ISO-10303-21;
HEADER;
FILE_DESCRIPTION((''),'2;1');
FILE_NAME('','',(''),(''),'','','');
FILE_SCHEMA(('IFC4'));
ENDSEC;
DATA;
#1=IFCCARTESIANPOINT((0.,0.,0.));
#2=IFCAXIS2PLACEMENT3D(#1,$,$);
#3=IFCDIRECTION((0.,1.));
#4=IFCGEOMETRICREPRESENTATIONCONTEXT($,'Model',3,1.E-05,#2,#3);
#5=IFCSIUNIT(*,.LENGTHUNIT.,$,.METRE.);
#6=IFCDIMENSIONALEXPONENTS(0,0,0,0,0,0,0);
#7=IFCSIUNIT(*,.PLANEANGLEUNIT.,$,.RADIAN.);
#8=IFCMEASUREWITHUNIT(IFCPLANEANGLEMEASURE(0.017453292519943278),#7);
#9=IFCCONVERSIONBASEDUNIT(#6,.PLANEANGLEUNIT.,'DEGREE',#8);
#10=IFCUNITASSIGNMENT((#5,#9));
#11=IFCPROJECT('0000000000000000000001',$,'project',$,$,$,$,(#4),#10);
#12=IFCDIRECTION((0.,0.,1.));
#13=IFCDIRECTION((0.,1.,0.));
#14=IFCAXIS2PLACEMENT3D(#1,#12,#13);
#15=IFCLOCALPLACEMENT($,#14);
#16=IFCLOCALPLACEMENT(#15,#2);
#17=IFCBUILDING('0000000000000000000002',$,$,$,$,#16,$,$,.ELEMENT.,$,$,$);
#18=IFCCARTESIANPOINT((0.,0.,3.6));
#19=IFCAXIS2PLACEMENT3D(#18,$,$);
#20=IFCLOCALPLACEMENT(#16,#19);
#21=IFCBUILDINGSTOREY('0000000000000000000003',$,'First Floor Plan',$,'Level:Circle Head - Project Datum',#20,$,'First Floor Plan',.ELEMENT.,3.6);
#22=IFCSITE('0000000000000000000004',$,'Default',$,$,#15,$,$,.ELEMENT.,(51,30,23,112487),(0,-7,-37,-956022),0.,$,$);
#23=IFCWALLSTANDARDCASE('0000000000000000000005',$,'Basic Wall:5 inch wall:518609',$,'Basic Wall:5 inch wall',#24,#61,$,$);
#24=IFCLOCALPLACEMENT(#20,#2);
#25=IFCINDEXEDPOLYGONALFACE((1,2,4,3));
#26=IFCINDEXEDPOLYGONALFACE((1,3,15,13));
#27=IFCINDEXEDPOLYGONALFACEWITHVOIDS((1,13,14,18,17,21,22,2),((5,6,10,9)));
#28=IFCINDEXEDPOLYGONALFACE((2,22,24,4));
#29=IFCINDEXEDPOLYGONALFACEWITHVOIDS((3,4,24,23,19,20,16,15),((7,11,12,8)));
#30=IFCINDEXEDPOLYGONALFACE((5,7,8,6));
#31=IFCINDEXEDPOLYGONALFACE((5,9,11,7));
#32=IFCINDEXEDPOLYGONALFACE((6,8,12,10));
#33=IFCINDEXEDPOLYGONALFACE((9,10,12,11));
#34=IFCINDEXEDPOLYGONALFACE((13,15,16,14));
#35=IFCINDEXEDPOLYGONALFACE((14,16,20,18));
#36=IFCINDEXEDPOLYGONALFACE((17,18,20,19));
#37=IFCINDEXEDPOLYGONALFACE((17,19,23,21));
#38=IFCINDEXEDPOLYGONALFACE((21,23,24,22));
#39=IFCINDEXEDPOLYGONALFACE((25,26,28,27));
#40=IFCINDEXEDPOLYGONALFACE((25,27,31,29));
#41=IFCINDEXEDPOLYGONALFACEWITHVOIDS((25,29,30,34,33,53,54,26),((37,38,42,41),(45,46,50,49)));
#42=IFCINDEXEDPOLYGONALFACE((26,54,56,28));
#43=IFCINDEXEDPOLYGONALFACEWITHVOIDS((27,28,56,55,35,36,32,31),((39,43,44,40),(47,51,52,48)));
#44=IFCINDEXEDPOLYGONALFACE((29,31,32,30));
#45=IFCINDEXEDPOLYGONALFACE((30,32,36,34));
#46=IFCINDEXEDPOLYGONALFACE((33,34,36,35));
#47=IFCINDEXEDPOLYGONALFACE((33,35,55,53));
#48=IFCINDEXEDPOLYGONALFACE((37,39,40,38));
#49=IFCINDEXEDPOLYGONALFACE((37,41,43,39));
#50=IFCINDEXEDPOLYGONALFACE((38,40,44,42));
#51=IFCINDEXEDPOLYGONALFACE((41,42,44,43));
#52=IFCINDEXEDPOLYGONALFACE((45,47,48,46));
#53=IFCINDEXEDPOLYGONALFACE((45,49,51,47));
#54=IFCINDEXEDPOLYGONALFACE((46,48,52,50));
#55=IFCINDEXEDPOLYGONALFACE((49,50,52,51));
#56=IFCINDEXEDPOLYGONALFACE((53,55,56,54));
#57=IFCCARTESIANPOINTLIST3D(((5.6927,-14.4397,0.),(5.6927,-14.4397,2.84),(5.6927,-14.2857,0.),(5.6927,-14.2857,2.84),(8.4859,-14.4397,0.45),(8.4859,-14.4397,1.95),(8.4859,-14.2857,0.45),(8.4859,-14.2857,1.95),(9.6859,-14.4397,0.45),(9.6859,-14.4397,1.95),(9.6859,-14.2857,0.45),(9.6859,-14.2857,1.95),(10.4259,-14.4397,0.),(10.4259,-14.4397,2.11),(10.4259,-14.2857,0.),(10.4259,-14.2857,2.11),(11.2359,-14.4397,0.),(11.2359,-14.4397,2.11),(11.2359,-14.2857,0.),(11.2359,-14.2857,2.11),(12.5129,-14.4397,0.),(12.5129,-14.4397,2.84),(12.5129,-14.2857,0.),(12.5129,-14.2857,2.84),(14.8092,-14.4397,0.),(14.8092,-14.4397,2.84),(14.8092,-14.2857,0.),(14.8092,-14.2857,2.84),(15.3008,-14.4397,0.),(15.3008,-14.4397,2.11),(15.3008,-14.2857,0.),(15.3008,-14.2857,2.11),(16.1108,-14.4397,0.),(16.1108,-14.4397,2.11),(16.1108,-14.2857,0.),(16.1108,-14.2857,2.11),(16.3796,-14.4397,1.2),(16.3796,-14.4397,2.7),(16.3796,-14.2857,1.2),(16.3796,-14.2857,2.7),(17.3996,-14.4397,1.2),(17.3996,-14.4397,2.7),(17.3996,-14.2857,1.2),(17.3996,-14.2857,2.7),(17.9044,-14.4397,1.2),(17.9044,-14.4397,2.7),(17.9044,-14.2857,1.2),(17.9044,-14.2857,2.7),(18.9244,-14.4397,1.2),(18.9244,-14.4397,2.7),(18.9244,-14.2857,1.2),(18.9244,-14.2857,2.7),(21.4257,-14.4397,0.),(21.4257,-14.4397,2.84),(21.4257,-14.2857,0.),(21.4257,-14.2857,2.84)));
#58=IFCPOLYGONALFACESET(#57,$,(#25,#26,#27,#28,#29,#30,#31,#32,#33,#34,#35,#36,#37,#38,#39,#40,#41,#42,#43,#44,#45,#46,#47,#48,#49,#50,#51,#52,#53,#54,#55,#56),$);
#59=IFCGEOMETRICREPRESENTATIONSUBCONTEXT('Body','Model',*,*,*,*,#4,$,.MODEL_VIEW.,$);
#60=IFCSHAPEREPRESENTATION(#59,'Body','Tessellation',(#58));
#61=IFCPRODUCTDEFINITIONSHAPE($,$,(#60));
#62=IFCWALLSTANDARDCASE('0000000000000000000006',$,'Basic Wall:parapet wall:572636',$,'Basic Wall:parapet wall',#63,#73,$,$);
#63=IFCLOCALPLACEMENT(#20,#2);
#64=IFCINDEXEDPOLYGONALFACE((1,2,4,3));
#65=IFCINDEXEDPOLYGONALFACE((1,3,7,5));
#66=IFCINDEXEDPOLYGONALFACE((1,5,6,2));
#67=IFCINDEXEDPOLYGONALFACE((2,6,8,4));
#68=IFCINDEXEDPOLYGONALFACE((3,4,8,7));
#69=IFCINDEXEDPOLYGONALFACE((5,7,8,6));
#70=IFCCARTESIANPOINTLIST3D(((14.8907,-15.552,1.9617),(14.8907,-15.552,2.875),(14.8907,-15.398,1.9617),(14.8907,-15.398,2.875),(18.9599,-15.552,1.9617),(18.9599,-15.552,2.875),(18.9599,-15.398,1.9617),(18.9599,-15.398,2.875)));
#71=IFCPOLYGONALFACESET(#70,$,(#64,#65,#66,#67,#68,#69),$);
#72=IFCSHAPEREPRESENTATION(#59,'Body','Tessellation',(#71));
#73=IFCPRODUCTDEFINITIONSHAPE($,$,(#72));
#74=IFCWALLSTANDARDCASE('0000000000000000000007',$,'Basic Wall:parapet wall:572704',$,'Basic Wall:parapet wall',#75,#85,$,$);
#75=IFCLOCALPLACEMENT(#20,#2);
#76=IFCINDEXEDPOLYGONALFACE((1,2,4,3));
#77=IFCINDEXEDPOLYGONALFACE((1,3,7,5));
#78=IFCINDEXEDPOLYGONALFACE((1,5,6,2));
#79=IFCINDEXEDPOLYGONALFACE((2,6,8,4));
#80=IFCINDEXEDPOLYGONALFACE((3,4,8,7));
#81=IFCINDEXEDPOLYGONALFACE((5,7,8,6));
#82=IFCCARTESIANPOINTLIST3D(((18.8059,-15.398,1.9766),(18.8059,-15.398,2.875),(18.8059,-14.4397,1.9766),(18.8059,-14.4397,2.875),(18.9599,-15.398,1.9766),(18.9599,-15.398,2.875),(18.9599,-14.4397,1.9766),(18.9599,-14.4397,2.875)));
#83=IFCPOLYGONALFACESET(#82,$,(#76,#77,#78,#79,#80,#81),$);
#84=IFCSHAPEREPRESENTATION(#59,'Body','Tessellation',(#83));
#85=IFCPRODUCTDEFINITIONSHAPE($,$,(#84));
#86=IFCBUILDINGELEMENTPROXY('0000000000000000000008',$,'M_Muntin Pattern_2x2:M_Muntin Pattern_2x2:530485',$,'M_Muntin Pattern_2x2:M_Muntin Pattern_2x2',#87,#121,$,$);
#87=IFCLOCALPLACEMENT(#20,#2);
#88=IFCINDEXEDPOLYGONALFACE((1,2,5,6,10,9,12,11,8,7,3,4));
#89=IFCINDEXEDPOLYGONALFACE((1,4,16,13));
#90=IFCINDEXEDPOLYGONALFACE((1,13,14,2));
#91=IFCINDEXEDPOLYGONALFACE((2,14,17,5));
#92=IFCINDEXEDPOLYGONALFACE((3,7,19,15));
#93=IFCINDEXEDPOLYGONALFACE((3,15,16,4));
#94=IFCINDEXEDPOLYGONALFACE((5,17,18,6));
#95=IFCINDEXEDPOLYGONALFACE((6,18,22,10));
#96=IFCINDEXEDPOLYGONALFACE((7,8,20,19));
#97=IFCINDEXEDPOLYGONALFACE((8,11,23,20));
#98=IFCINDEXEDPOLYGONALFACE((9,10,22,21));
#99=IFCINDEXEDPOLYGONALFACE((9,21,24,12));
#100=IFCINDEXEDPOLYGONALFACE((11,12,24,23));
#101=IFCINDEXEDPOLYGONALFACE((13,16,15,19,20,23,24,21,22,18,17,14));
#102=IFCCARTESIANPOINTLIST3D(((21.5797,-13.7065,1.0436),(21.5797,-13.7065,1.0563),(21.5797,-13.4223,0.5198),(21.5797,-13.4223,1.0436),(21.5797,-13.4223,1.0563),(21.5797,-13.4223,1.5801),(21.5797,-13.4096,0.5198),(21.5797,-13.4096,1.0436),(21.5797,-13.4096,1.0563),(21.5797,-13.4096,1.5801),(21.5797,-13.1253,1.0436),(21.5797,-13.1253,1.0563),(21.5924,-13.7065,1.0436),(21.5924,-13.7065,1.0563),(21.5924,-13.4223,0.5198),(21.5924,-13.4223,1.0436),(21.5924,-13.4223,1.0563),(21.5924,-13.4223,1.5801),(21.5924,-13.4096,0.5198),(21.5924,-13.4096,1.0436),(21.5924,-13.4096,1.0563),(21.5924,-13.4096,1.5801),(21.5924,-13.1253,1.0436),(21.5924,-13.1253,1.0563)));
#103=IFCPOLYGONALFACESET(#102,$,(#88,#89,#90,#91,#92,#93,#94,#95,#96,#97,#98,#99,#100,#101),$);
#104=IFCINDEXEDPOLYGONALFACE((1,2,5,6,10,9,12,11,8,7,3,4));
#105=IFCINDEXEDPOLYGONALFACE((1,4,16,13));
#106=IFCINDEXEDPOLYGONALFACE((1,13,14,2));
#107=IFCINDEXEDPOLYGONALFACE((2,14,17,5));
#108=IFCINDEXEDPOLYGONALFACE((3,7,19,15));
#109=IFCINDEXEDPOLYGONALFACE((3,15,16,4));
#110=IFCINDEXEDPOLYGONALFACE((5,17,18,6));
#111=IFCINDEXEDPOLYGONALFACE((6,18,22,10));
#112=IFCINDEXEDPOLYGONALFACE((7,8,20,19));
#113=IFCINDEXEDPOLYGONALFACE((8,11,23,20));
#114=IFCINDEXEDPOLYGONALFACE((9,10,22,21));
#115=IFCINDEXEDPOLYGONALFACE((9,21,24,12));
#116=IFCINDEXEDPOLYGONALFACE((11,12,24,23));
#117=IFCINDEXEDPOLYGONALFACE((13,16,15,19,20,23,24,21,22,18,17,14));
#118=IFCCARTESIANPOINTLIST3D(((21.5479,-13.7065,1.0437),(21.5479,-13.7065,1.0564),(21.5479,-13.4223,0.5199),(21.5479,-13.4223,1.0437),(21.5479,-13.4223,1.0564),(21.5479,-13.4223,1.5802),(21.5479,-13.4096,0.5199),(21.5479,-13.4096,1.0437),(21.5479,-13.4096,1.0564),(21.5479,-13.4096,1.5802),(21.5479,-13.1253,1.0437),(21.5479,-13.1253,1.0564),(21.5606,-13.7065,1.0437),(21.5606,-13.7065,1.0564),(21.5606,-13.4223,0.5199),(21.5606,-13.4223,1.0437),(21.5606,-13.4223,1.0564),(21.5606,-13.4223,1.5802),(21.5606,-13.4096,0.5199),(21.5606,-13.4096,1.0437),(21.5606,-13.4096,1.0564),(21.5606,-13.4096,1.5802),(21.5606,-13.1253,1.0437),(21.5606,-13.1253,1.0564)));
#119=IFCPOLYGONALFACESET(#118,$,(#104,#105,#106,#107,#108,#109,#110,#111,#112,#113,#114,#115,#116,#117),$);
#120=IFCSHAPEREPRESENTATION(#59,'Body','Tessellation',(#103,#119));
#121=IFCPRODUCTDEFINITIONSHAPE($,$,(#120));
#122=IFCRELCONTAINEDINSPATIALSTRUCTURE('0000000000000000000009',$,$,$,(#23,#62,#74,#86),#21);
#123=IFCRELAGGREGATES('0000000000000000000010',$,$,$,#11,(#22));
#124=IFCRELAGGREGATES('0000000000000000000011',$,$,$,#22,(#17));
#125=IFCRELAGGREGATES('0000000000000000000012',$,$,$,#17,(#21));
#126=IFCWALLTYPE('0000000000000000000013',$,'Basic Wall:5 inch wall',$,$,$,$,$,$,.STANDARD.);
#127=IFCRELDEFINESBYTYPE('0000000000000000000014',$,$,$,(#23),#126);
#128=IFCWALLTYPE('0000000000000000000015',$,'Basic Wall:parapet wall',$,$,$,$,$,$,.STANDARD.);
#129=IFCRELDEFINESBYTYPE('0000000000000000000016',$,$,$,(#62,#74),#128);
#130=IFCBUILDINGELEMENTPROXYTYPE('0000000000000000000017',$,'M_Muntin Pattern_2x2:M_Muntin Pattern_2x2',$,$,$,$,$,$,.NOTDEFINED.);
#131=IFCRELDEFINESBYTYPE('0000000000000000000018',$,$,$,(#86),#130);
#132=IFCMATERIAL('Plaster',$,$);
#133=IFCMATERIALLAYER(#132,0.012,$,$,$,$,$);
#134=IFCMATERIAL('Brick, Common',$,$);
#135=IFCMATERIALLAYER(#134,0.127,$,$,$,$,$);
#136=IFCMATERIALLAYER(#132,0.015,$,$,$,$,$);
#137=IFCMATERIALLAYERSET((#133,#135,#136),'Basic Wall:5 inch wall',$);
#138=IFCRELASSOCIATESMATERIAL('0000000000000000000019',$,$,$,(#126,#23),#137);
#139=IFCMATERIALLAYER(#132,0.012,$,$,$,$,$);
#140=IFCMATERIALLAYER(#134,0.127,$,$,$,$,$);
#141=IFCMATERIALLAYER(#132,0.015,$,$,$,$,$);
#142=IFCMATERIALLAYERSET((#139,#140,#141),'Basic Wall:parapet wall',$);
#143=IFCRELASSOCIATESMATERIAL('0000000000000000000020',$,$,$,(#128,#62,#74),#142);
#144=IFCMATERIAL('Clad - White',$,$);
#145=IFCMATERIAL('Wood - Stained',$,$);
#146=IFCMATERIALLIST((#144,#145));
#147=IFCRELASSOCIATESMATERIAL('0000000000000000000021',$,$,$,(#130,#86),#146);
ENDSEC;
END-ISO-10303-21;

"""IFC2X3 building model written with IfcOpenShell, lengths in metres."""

from ifc_helpers import new_model, entity, si_unit, converted_unit, direction, frame, frame_2d, origin, place, context, subcontext, project, spatial, polyline, rectangle, outline, extrude, clip, bounded_halfspace, source, transform, mapped, material, material_list, layer, layer_set, layer_usage, type_object, type_shapes, element, save


model = new_model("IFC2X3")

# Units and contexts
model_context = context("Model", 3, precision=1e-05, world=origin(), true_north=direction((0.0, 1.0)))
body_context = subcontext(model_context, "Body", "Model", "MODEL_VIEW")
ifc_project = project(units=[si_unit("LENGTHUNIT", "METRE"), converted_unit("PLANEANGLEUNIT", "DEGREE", entity("IfcPlaneAngleMeasure", 0.017453292519943278), si_unit("PLANEANGLEUNIT", "RADIAN"), dimensions=[0, 0, 0, 0, 0, 0, 0])], contexts=[model_context])

# Site, building, storey
site_placement = place(None, frame((0.0, 0.0, 0.0), z_axis=(0.0, 0.0, 1.0), x_axis=(0.0, 1.0, 0.0)))
site = spatial("IfcSite", under=ifc_project, at=site_placement, Name="Default", CompositionType="ELEMENT", RefLatitude=(51, 30, 23, 112487), RefLongitude=(0, -7, -37, -956022), RefElevation=0.0)
building_placement = place(site_placement, origin())
building = spatial("IfcBuilding", under=site, at=building_placement, CompositionType="ELEMENT")
storey_placement = place(building_placement, frame((0.0, 0.0, 3.6)))
storey = spatial("IfcBuildingStorey", under=building, at=storey_placement, Name="First Floor Plan", ObjectType="Level:Circle Head - Project Datum", LongName="First Floor Plan", CompositionType="ELEMENT", Elevation=3.6)

# Wall, openings
ifc_material_1 = material(Name="Plaster")
ifc_layer_1 = layer(ifc_material_1, 0.012)
ifc_material_2 = material(Name="Brick, Common")
ifc_layer_2 = layer(ifc_material_2, 0.127)
ifc_layer_3 = layer(ifc_material_1, 0.015)
ifc_layer_set_1 = layer_set([ifc_layer_1, ifc_layer_2, ifc_layer_3], Name="Basic Wall:5 inch wall")
ifc_layer_usage_1 = layer_usage(ifc_layer_set_1, "AXIS2", "NEGATIVE", 0.077)
wall_type_1 = type_object("IfcWallType", Name="Basic Wall:5 inch wall", PredefinedType="STANDARD", material=ifc_layer_set_1)
wall_1_placement = place(storey_placement, frame((21.4257, -14.3627, 0.0), z_axis=(0.0, 0.0, 1.0), x_axis=(-1.0, 0.0, 0.0)))
wall_1 = element("IfcWallStandardCase", 1, at=wall_1_placement, inside=storey, type_object=wall_type_1, material=ifc_layer_usage_1, Name="Basic Wall:5 inch wall:518609", ObjectType="Basic Wall:5 inch wall", context=body_context, shape_type="SweptSolid", body=[
    extrude(rectangle(XDim=15.733, YDim=0.154, at=frame_2d((7.8665, 0.0), x_axis=(-1.0, 0.0))), origin(), (0.0, 0.0, 1.0), 2.84),
])
opening_1_placement = place(wall_1_placement, origin())
element("IfcOpeningElement", 2, at=opening_1_placement, cuts=wall_1, ObjectType="Opening", context=body_context, shape_type="SweptSolid", body=[
    extrude(rectangle(XDim=3.0671, YDim=2.2963, at=frame_2d((0.0, 0.0), x_axis=(1.0, 0.0))), frame((7.7646, -0.077, 1.436), z_axis=(0.0, 1.0, 0.0), x_axis=(0.0, 0.0, -1.0)), (0.0, 0.0, 1.0), 0.154),
])
opening_2_placement = place(wall_1_placement, origin())
element("IfcOpeningElement", 3, at=opening_2_placement, cuts=wall_1, ObjectType="Opening", context=body_context, shape_type="SweptSolid", body=[
    extrude(rectangle(XDim=2.11, YDim=0.154, at=frame_2d((0.0, 0.0), x_axis=(0.0, 1.0))), frame((11.256, -1.087, 1.055), z_axis=(0.0, 1.0, 0.0), x_axis=(-1.0, 0.0, 0.0)), (0.0, 0.0, 1.0), 1.01),
])
opening_3_placement = place(wall_1_placement, frame((10.1897, -0.077, 0.0)))
element("IfcOpeningElement", 4, at=opening_3_placement, cuts=wall_1, ObjectType="Opening", context=body_context, shape_type="SweptSolid", body=[
    extrude(rectangle(XDim=2.11, YDim=0.81, at=frame_2d((1.055, 0.405), x_axis=(1.0, 0.0))), frame((0.0, 0.0, 0.0), z_axis=(0.0, 1.0, 0.0), x_axis=(0.0, 0.0, 1.0)), (0.0, 0.0, 1.0), 0.154),
])
opening_4_placement = place(wall_1_placement, frame((5.3149, -0.077, 0.0)))
element("IfcOpeningElement", 5, at=opening_4_placement, cuts=wall_1, ObjectType="Opening", context=body_context, shape_type="SweptSolid", body=[
    extrude(rectangle(XDim=2.11, YDim=0.81, at=frame_2d((1.055, 0.405), x_axis=(1.0, 0.0))), frame((0.0, 0.0, 0.0), z_axis=(0.0, 1.0, 0.0), x_axis=(0.0, 0.0, 1.0)), (0.0, 0.0, 1.0), 0.154),
])
opening_5_placement = place(wall_1_placement, frame((11.7397, -0.077, 0.45)))
element("IfcOpeningElement", 6, at=opening_5_placement, cuts=wall_1, ObjectType="Opening", context=body_context, shape_type="SweptSolid", body=[
    extrude(rectangle(XDim=1.5, YDim=1.2, at=frame_2d((0.75, 0.6), x_axis=(-1.0, 0.0))), frame((0.0, 0.0, 0.0), z_axis=(0.0, 1.0, 0.0), x_axis=(0.0, 0.0, 1.0)), (0.0, 0.0, 1.0), 0.154),
])
opening_6_placement = place(wall_1_placement, frame((4.0261, -0.077, 1.2)))
element("IfcOpeningElement", 7, at=opening_6_placement, cuts=wall_1, ObjectType="Opening", context=body_context, shape_type="SweptSolid", body=[
    extrude(rectangle(XDim=1.5, YDim=1.02, at=frame_2d((0.75, 0.51), x_axis=(-1.0, 0.0))), frame((0.0, 0.0, 0.0), z_axis=(0.0, 1.0, 0.0), x_axis=(0.0, 0.0, 1.0)), (0.0, 0.0, 1.0), 0.154),
])
opening_7_placement = place(wall_1_placement, frame((2.5013, -0.077, 1.2)))
element("IfcOpeningElement", 8, at=opening_7_placement, cuts=wall_1, ObjectType="Opening", context=body_context, shape_type="SweptSolid", body=[
    extrude(rectangle(XDim=1.5, YDim=1.02, at=frame_2d((0.75, 0.51), x_axis=(-1.0, 0.0))), frame((0.0, 0.0, 0.0), z_axis=(0.0, 1.0, 0.0), x_axis=(0.0, 0.0, 1.0)), (0.0, 0.0, 1.0), 0.154),
])

# Walls
ifc_layer_4 = layer(ifc_material_1, 0.012)
ifc_layer_5 = layer(ifc_material_2, 0.127)
ifc_layer_6 = layer(ifc_material_1, 0.015)
ifc_layer_set_2 = layer_set([ifc_layer_4, ifc_layer_5, ifc_layer_6], Name="Basic Wall:parapet wall")
ifc_layer_usage_2 = layer_usage(ifc_layer_set_2, "AXIS2", "NEGATIVE", 0.077)
wall_type_2 = type_object("IfcWallType", Name="Basic Wall:parapet wall", PredefinedType="STANDARD", material=ifc_layer_set_2)
wall_2_placement = place(storey_placement, frame((14.8907, -15.475, 1.9617)))
element("IfcWallStandardCase", 9, at=wall_2_placement, inside=storey, type_object=wall_type_2, material=ifc_layer_usage_2, Name="Basic Wall:parapet wall:572636", ObjectType="Basic Wall:parapet wall", context=body_context, shape_type="Clipping", body=[
    clip(extrude(rectangle(XDim=4.0693, YDim=0.154, at=frame_2d((2.0346, 0.0), x_axis=(-1.0, 0.0))), origin(), (0.0, 0.0, 1.0), 0.9133), bounded_halfspace(frame((0.0, -0.077, 0.9133), z_axis=(0.0, 0.0, -1.0), x_axis=(0.0, -1.0, 0.0)), True, frame((0.0, -0.077, 0.9133)), polyline([(0.0, 0.0), (4.0693, 0.0), (4.0693, 0.154), (3.9153, 0.154), (0.0, 0.154), (0.0, 0.0)]))),
])
ifc_layer_usage_3 = layer_usage(ifc_layer_set_2, "AXIS2", "NEGATIVE", 0.077)
wall_3_placement = place(storey_placement, frame((18.8829, -15.398, 1.9766), z_axis=(0.0, 0.0, 1.0), x_axis=(0.0, 1.0, 0.0)))
element("IfcWallStandardCase", 10, at=wall_3_placement, inside=storey, type_object=wall_type_2, material=ifc_layer_usage_3, Name="Basic Wall:parapet wall:572704", ObjectType="Basic Wall:parapet wall", context=body_context, shape_type="Clipping", body=[
    clip(extrude(rectangle(XDim=0.9583, YDim=0.154, at=frame_2d((0.4791, 0.0), x_axis=(-1.0, 0.0))), origin(), (0.0, 0.0, 1.0), 0.8984), bounded_halfspace(frame((0.0, -0.077, 0.8984), z_axis=(0.0, 0.0, -1.0), x_axis=(-1.0, 0.0, 0.0)), True, frame((0.0, -0.077, 0.8984)), polyline([(0.0, 0.0), (0.9583, 0.0), (0.9583, 0.154), (0.0, 0.154), (0.0, 0.0)]))),
])

# Building element proxy
ifc_material_3 = material(Name="Clad - White")
ifc_material_4 = material(Name="Wood - Stained")
ifc_material_list = material_list([ifc_material_3, ifc_material_4])
building_element_proxy_type_1 = type_object("IfcBuildingElementProxyType", Name="M_Muntin Pattern_2x2:M_Muntin Pattern_2x2", PredefinedType="NOTDEFINED", material=ifc_material_list)
shared_shape_1 = source(origin(), body_context, "Body", "SweptSolid", [
    extrude(outline(polyline([(0.0064, -0.0064), (0.5301, -0.0064), (0.5301, 0.0063), (0.0064, 0.0063), (0.0064, 0.2906), (-0.0063, 0.2906), (-0.0063, 0.0063), (-0.5302, 0.0063), (-0.5302, -0.0064), (-0.0063, -0.0064), (-0.0063, -0.2906), (0.0064, -0.2906), (0.0064, -0.0064)])), frame((0.0, -0.0222, 0.5301), z_axis=(0.0, 1.0, 0.0), x_axis=(0.0, 0.0, 1.0)), (0.0, 0.0, 1.0), 0.0127),
    extrude(outline(polyline([(0.0064, -0.0064), (0.5302, -0.0064), (0.5302, 0.0063), (0.0064, 0.0063), (0.0064, 0.2906), (-0.0063, 0.2906), (-0.0063, 0.0063), (-0.5302, 0.0063), (-0.5302, -0.0064), (-0.0063, -0.0064), (-0.0063, -0.2906), (0.0064, -0.2906), (0.0064, -0.0064)])), frame((0.0, 0.0095, 0.5302), z_axis=(0.0, 1.0, 0.0), x_axis=(0.0, 0.0, 1.0)), (0.0, 0.0, 1.0), 0.0127),
])
type_shapes(building_element_proxy_type_1, [shared_shape_1])
proxy_1_placement = place(storey_placement, frame((21.5701, -13.4159, 0.5199), z_axis=(0.0, 0.0, 1.0), x_axis=(0.0, 1.0, 0.0)))
element("IfcBuildingElementProxy", 11, at=proxy_1_placement, inside=storey, type_object=building_element_proxy_type_1, material=ifc_material_list, Name="M_Muntin Pattern_2x2:M_Muntin Pattern_2x2:530485", ObjectType="M_Muntin Pattern_2x2:M_Muntin Pattern_2x2", context=body_context, shape_type="MappedRepresentation", body=[
    mapped(shared_shape_1, transform((0.0, 0.0, 0.0), scale=1.0)),
])

save(model, "model.ifc")
